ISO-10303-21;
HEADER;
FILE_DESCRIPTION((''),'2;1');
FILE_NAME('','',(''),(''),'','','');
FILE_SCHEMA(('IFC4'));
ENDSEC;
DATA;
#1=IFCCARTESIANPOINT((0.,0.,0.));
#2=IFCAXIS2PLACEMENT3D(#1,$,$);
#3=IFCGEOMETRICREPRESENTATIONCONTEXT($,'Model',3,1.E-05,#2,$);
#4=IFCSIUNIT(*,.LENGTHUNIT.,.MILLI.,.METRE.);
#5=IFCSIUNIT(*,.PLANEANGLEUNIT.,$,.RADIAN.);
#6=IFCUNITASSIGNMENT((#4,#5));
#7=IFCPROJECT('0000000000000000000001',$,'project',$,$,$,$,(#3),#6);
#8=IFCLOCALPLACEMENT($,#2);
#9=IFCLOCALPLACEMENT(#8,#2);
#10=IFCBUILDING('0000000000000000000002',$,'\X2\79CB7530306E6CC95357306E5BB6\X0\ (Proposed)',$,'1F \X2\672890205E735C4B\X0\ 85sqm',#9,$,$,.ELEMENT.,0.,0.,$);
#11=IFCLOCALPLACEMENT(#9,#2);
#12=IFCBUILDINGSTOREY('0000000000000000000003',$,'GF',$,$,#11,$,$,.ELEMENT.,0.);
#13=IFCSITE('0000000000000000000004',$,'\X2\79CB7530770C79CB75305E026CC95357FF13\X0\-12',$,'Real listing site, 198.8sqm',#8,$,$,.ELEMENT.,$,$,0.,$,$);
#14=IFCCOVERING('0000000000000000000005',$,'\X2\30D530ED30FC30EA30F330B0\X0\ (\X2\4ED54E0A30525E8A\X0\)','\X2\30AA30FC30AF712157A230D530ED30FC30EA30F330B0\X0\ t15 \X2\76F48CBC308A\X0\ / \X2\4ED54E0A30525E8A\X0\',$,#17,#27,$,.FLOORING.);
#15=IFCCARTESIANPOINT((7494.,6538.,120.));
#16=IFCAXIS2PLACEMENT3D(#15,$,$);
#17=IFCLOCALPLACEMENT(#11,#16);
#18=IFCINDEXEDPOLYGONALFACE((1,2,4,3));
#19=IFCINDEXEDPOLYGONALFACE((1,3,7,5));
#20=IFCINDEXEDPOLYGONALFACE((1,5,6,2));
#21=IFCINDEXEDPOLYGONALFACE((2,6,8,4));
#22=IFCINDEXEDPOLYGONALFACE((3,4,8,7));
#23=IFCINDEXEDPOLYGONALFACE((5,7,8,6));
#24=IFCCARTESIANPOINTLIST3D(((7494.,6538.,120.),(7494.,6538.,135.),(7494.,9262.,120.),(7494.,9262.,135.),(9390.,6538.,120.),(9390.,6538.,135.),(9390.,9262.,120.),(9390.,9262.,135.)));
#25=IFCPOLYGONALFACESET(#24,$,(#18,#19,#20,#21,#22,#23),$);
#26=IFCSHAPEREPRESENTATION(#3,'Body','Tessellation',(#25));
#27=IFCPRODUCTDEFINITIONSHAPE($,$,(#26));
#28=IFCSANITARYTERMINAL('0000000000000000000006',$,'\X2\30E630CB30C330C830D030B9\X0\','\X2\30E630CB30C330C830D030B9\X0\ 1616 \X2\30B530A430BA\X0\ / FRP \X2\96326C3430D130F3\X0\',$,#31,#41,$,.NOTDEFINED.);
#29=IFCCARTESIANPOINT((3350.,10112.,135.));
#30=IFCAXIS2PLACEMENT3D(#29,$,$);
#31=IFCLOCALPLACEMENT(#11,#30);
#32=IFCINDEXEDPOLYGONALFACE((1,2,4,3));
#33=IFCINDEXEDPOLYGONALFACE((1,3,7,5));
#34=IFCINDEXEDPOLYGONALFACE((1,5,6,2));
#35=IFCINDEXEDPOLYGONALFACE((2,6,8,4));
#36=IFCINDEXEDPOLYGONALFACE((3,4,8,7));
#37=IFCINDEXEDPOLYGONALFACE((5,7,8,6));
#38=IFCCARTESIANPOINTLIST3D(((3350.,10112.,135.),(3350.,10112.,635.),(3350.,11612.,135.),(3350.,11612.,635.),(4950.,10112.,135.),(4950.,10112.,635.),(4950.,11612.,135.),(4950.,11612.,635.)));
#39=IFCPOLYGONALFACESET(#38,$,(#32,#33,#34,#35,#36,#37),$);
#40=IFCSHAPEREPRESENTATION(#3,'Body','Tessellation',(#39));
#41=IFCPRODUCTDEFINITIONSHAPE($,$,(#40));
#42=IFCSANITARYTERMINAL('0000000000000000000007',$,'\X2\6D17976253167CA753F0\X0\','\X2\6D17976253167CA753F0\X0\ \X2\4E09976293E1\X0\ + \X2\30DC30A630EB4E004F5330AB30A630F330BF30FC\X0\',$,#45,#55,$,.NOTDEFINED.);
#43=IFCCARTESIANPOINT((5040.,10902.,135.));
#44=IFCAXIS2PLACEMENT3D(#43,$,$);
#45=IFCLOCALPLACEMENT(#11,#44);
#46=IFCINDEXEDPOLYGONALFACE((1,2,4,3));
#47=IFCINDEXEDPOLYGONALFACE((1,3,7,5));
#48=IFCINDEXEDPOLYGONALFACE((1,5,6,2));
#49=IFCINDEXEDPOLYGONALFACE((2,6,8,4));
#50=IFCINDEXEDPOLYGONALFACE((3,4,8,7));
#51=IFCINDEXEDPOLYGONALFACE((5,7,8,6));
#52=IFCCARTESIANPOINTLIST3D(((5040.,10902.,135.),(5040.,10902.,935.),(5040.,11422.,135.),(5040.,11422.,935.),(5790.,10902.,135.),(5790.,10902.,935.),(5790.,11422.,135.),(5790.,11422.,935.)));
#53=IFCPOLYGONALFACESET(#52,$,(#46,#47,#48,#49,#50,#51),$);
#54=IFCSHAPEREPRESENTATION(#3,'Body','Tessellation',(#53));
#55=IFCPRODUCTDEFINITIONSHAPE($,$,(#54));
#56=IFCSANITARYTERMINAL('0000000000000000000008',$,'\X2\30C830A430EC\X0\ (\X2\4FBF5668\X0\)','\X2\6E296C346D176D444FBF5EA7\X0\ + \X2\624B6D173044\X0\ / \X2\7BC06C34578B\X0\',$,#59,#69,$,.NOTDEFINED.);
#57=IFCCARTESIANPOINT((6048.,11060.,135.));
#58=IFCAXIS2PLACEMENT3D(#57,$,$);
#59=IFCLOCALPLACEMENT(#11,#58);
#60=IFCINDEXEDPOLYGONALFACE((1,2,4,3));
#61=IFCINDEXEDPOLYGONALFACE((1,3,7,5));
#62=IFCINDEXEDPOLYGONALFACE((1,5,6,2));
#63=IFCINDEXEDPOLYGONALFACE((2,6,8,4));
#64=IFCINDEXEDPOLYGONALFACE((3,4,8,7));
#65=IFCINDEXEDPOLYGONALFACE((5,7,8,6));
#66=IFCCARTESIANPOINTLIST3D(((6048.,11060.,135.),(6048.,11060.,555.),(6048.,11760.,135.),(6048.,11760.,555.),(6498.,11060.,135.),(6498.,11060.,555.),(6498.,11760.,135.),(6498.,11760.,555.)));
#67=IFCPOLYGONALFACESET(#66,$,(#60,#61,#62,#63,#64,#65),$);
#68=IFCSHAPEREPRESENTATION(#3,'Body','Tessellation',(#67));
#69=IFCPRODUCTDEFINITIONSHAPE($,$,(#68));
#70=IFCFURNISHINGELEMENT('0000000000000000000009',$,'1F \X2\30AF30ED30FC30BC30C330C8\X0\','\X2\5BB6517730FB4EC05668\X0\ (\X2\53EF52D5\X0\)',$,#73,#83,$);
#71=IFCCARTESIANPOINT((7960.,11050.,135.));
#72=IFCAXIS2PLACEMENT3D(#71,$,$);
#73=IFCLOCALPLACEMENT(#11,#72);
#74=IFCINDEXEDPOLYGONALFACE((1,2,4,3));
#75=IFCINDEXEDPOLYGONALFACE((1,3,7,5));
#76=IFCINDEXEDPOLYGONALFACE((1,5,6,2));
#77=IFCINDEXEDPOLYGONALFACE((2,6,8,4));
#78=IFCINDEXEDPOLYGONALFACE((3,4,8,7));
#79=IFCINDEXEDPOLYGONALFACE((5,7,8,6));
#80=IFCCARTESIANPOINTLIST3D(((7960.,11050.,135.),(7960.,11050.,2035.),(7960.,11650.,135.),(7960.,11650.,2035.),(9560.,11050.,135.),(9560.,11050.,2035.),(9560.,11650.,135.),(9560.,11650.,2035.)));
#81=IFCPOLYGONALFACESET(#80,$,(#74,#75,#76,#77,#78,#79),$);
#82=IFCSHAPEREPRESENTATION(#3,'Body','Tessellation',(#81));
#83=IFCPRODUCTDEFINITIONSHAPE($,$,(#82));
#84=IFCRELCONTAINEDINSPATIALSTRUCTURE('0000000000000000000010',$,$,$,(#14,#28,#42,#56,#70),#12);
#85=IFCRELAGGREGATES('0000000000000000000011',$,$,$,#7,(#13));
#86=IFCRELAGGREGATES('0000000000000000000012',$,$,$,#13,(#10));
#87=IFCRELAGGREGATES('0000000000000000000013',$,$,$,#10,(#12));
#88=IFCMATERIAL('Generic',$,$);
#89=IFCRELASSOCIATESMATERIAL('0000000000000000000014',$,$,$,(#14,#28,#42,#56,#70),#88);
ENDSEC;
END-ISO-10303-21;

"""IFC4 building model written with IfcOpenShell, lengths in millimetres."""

from ifc_helpers import new_model, si_unit, frame, frame_2d, origin, place, context, project, spatial, rectangle, extrude, material, element, save


model = new_model("IFC4")

# Units and contexts
model_context = context("Model", 3, precision=1e-05, world=origin())
ifc_project = project(units=[si_unit("LENGTHUNIT", "METRE", prefix="MILLI"), si_unit("PLANEANGLEUNIT", "RADIAN")], contexts=[model_context])

# Site, building, storey
site_placement = place(None, origin())
site = spatial("IfcSite", under=ifc_project, at=site_placement, Name="秋田県秋田市泉南３-12", ObjectType="Real listing site, 198.8sqm", CompositionType="ELEMENT", RefElevation=0.0)
building_placement = place(site_placement, origin())
building = spatial("IfcBuilding", under=site, at=building_placement, Name="秋田の泉南の家 (Proposed)", ObjectType="1F 木造平屋 85sqm", CompositionType="ELEMENT", ElevationOfRefHeight=0.0, ElevationOfTerrain=0.0)
storey_placement = place(building_placement, origin())
storey = spatial("IfcBuildingStorey", under=building, at=storey_placement, Name="GF", CompositionType="ELEMENT", Elevation=0.0)

# Covering
ifc_material_1 = material(Name="Generic")
covering_1_placement = place(storey_placement, frame((7494.0, 6538.0, 120.0)))
element("IfcCovering", 1, at=covering_1_placement, inside=storey, material=ifc_material_1, Name="フローリング (仕上げ床)", Description="オーク無垢フローリング t15 直貼り / 仕上げ床", PredefinedType="FLOORING", context=model_context, shape_type="SweptSolid", body=[
    extrude(rectangle(XDim=1896.0, YDim=2724.0, at=frame_2d((948.0, 1362.0))), frame((7494.0, 6538.0, 120.0)), (0.0, 0.0, 1.0), 15.0),
])

# Sanitary terminals
sanitary_terminal_1_placement = place(storey_placement, frame((3350.0, 10112.0, 135.0)))
element("IfcSanitaryTerminal", 2, at=sanitary_terminal_1_placement, inside=storey, material=ifc_material_1, Name="ユニットバス", Description="ユニットバス 1616 サイズ / FRP 防水パン", PredefinedType="NOTDEFINED", context=model_context, shape_type="SweptSolid", body=[
    extrude(rectangle(XDim=1600.0, YDim=1500.0, at=frame_2d((800.0, 750.0))), frame((3350.0, 10112.0, 135.0)), (0.0, 0.0, 1.0), 500.0),
])
sanitary_terminal_2_placement = place(storey_placement, frame((5040.0, 10902.0, 135.0)))
element("IfcSanitaryTerminal", 3, at=sanitary_terminal_2_placement, inside=storey, material=ifc_material_1, Name="洗面化粧台", Description="洗面化粧台 三面鏡 + ボウル一体カウンター", PredefinedType="NOTDEFINED", context=model_context, shape_type="SweptSolid", body=[
    extrude(rectangle(XDim=750.0, YDim=520.0, at=frame_2d((375.0, 260.0))), frame((5040.0, 10902.0, 135.0)), (0.0, 0.0, 1.0), 800.0),
])
sanitary_terminal_3_placement = place(storey_placement, frame((6048.0, 11060.0, 135.0)))
element("IfcSanitaryTerminal", 4, at=sanitary_terminal_3_placement, inside=storey, material=ifc_material_1, Name="トイレ (便器)", Description="温水洗浄便座 + 手洗い / 節水型", PredefinedType="NOTDEFINED", context=model_context, shape_type="SweptSolid", body=[
    extrude(rectangle(XDim=450.0, YDim=700.0, at=frame_2d((225.0, 350.0))), frame((6048.0, 11060.0, 135.0)), (0.0, 0.0, 1.0), 420.0),
])

# Furnishing element
furnishing_placement = place(storey_placement, frame((7960.0, 11050.0, 135.0)))
element("IfcFurnishingElement", 5, at=furnishing_placement, inside=storey, material=ifc_material_1, Name="1F クローゼット", Description="家具・什器 (可動)", context=model_context, shape_type="SweptSolid", body=[
    extrude(rectangle(XDim=1600.0, YDim=600.0, at=frame_2d((800.0, 300.0))), frame((7960.0, 11050.0, 135.0)), (0.0, 0.0, 1.0), 1900.0),
])

save(model, "model.ifc")
